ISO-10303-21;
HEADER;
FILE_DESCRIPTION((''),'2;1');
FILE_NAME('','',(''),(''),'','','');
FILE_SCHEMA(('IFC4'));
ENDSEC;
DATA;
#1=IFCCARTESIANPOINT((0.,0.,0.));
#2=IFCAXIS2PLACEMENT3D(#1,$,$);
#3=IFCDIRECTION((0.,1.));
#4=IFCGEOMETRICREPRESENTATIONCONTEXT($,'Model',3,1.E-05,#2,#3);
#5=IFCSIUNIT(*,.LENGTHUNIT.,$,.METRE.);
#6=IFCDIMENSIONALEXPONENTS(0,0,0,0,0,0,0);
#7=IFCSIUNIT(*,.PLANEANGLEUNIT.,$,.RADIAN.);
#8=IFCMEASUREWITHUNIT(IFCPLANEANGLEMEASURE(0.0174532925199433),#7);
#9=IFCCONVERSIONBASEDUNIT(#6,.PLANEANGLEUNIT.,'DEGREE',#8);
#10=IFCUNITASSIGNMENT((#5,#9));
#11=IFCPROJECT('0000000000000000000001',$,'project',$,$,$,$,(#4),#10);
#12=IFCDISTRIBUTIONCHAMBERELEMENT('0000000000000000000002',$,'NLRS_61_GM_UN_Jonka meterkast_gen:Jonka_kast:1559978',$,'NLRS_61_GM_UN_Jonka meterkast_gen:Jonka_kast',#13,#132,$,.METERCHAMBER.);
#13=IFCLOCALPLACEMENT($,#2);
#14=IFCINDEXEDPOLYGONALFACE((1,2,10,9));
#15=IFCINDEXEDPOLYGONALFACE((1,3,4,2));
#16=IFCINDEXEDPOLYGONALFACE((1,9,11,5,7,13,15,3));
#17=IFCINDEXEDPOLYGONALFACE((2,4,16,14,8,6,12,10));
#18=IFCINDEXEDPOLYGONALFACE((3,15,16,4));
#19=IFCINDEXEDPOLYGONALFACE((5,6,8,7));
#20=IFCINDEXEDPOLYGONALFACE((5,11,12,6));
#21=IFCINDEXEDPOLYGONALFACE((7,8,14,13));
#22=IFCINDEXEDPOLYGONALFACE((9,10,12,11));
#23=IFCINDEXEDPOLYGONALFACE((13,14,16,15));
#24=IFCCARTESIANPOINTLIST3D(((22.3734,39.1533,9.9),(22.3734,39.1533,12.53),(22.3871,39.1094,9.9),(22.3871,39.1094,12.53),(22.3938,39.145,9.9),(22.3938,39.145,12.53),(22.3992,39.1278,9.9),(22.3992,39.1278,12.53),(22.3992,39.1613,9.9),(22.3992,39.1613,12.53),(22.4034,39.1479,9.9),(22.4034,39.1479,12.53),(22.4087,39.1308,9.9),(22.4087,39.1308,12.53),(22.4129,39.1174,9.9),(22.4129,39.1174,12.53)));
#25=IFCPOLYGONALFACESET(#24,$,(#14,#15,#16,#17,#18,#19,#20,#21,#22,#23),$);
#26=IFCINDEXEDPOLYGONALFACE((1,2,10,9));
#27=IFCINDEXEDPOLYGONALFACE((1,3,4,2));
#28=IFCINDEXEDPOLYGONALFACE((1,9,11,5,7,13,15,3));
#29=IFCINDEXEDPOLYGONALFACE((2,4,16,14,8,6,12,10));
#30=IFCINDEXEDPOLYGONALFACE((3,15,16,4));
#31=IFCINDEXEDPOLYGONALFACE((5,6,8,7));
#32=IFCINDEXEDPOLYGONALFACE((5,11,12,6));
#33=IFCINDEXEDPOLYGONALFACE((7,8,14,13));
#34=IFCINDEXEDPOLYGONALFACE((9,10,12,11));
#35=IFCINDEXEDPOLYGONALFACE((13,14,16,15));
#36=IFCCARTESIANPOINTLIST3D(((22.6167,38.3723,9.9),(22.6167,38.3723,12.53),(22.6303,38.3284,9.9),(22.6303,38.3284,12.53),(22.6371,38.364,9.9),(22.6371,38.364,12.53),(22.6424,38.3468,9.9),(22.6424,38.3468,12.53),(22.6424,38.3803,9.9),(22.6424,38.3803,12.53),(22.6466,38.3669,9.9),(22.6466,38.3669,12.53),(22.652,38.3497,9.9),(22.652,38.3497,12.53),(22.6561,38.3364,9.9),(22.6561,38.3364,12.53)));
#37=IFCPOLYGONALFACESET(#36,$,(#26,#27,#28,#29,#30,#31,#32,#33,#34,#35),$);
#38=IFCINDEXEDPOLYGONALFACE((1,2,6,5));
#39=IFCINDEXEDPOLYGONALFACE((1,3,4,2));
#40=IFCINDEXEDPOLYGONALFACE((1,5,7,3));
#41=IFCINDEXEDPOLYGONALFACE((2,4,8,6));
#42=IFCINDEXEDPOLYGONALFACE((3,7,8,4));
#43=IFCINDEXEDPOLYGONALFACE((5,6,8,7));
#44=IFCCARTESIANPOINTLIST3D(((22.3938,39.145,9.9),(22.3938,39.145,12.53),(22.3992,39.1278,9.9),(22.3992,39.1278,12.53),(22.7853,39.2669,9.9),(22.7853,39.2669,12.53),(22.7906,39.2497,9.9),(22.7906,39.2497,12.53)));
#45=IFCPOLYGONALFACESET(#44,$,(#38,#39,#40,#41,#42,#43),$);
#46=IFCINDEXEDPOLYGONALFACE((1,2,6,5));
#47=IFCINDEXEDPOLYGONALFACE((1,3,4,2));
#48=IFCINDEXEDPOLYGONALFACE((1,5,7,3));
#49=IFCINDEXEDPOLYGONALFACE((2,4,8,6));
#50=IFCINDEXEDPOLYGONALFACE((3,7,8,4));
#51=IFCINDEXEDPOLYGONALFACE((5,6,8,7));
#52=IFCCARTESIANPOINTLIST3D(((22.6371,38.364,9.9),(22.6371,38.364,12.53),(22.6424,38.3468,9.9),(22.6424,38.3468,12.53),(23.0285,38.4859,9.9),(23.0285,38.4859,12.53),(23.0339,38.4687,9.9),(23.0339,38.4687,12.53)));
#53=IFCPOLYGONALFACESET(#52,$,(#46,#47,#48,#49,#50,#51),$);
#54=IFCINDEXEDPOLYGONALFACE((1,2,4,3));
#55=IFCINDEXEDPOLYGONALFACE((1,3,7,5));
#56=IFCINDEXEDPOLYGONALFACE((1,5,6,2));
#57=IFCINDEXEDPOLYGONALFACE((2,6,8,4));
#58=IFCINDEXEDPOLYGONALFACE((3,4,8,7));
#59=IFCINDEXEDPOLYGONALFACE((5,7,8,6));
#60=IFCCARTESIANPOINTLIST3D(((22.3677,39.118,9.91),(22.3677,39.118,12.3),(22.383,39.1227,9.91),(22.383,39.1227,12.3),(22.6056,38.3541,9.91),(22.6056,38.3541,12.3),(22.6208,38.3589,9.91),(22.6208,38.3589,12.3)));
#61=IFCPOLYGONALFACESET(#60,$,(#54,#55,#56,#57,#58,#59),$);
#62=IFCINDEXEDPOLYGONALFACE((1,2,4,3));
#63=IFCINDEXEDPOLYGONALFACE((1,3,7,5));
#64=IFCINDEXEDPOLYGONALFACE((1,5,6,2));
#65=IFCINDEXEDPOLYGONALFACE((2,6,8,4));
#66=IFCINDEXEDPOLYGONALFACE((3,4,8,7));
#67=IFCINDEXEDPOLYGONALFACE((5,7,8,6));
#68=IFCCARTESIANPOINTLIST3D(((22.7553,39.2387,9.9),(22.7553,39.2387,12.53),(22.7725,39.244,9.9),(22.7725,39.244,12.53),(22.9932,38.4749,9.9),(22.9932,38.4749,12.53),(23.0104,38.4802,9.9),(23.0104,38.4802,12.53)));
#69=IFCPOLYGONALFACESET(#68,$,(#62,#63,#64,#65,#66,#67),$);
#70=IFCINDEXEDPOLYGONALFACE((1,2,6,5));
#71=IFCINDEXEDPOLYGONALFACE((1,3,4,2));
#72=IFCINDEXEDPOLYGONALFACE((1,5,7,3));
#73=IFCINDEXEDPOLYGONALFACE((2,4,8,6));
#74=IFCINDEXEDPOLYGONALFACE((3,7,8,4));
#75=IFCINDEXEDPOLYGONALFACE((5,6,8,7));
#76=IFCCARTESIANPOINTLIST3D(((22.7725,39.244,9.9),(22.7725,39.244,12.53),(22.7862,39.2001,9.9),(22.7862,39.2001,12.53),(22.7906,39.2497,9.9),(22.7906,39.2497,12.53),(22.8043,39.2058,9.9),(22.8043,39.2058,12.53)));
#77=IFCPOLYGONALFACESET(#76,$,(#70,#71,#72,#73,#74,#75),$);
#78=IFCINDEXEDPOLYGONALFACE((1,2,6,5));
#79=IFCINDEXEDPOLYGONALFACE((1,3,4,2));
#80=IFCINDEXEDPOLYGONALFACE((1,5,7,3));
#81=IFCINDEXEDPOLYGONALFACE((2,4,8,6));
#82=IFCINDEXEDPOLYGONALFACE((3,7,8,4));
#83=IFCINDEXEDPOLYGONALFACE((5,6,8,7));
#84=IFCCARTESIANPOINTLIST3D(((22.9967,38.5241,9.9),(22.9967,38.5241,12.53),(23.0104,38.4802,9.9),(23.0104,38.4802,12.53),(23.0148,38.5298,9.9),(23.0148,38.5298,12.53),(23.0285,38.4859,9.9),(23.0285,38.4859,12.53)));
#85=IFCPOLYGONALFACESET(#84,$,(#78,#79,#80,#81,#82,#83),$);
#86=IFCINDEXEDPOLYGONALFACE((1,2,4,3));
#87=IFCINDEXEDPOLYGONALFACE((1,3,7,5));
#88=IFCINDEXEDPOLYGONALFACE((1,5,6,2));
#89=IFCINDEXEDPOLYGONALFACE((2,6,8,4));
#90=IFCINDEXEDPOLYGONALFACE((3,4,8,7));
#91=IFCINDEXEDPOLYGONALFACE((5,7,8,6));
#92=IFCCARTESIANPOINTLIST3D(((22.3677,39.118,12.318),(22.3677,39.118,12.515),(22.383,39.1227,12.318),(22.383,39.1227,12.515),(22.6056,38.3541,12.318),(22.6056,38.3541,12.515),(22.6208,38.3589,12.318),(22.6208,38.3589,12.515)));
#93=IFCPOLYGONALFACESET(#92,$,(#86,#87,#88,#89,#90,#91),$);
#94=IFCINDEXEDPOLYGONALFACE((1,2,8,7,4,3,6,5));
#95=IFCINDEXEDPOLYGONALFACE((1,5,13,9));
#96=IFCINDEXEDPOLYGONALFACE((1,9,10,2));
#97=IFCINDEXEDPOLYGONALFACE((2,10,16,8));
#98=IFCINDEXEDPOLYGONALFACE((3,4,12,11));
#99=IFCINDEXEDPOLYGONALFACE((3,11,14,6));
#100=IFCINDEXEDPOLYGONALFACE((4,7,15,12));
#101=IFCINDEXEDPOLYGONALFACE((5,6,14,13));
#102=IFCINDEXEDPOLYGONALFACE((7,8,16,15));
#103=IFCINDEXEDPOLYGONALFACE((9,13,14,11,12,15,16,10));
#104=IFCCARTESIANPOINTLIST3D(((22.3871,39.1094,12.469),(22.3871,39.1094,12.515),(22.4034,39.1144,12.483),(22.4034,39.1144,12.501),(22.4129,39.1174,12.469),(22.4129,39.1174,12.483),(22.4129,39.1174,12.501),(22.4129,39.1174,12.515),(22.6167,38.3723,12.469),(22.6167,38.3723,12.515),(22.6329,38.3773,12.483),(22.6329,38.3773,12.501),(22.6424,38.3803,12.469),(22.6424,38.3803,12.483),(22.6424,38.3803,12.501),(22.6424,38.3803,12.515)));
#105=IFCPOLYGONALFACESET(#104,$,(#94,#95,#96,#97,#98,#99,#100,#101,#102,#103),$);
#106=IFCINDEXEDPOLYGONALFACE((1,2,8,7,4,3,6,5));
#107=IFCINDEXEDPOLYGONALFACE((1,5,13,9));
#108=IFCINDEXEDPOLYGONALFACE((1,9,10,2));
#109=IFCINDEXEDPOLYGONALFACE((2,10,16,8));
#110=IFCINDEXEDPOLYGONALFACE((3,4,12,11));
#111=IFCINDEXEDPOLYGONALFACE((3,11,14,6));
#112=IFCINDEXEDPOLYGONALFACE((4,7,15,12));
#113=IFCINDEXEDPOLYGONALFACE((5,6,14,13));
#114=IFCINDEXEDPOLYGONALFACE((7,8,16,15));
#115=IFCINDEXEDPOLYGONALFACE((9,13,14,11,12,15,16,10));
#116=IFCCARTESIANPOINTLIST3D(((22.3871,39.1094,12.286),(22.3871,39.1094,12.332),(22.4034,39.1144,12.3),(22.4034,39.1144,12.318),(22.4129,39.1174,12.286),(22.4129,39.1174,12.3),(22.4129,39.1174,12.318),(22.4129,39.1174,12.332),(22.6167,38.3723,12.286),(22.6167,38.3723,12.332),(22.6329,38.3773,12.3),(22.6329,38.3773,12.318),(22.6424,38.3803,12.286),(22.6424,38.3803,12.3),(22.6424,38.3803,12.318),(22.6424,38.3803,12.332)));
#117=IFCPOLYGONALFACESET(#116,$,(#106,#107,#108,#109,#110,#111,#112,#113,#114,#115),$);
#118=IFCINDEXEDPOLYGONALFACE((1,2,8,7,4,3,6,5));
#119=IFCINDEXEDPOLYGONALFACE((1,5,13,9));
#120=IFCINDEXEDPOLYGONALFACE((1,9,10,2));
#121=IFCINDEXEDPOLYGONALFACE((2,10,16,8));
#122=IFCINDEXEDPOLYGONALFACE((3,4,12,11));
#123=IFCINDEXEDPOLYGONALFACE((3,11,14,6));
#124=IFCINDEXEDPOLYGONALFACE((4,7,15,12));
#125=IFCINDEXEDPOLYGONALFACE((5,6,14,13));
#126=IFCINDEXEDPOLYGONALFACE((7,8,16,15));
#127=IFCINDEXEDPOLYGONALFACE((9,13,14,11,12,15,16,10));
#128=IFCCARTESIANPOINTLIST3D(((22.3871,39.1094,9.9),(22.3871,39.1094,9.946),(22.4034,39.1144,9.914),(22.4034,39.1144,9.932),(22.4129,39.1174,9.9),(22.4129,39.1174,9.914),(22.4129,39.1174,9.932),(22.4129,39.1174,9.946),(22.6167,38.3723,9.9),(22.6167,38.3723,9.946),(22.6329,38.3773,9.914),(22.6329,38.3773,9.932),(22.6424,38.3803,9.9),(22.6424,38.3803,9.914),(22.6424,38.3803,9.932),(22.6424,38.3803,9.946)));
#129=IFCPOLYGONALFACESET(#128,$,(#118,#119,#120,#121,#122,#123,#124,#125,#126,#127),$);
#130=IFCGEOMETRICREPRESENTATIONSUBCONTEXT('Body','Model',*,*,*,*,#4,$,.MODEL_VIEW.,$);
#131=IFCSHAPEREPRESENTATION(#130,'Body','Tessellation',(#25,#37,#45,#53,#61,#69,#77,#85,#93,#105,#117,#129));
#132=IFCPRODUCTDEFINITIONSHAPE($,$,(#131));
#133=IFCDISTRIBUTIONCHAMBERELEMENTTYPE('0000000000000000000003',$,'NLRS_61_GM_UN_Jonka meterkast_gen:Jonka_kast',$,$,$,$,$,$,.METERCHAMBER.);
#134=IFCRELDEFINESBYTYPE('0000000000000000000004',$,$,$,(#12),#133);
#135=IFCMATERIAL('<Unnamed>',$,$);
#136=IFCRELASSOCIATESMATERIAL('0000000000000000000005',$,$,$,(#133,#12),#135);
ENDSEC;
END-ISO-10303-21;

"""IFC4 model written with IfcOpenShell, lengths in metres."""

from ifc_helpers import new_model, entity, si_unit, converted_unit, direction, frame, origin, place, context, subcontext, project, indexed_curve, outline, extrude, source, transform, mapped, material, type_object, type_shapes, element, save


model = new_model("IFC4")

# Units and contexts
model_context = context("Model", 3, precision=1e-05, world=origin(), true_north=direction((0.0, 1.0)))
body_context = subcontext(model_context, "Body", "Model", "MODEL_VIEW")
ifc_project = project(units=[si_unit("LENGTHUNIT", "METRE"), converted_unit("PLANEANGLEUNIT", "DEGREE", entity("IfcPlaneAngleMeasure", 0.0174532925199433), si_unit("PLANEANGLEUNIT", "RADIAN"), dimensions=[0, 0, 0, 0, 0, 0, 0])], contexts=[model_context])

# Distribution chamber element
ifc_material = material(Name="<Unnamed>")
distribution_chamber_element_type = type_object("IfcDistributionChamberElementType", Name="NLRS_61_GM_UN_Jonka meterkast_gen:Jonka_kast", PredefinedType="METERCHAMBER", material=ifc_material)
shared_shape_1 = source(origin(), body_context, "Body", "SweptSolid", [
    extrude(outline(indexed_curve([(-0.0093, -0.023), (0.0178, -0.023), (0.0178, 0.023), (-0.0093, 0.023), (-0.0093, 0.009), (0.0007, 0.009), (0.0007, -0.009), (-0.0093, -0.009), (-0.0093, -0.023)], self_intersect=False)), frame((-0.409, -0.4092, 0.0), z_axis=(0.0, 0.0, 1.0), x_axis=(0.0, -1.0, 0.0)), (0.0, 0.0, 1.0), 2.63),
    extrude(outline(indexed_curve([(-0.0093, -0.023), (0.0178, -0.023), (0.0178, 0.023), (-0.0093, 0.023), (-0.0093, 0.009), (0.0007, 0.009), (0.0007, -0.009), (-0.0093, -0.009), (-0.0093, -0.023)], self_intersect=False)), frame((0.409, -0.4092, 0.0), z_axis=(0.0, 0.0, 1.0), x_axis=(0.0, -1.0, 0.0)), (0.0, 0.0, 1.0), 2.63),
    extrude(outline(indexed_curve([(-0.205, -0.009), (0.205, -0.009), (0.205, 0.009), (-0.205, 0.009), (-0.205, -0.009)], self_intersect=False)), frame((-0.409, -0.205, 0.0), z_axis=(0.0, 0.0, 1.0), x_axis=(0.0, -1.0, 0.0)), (0.0, 0.0, 1.0), 2.63),
    extrude(outline(indexed_curve([(-0.205, -0.009), (0.205, -0.009), (0.205, 0.009), (-0.205, 0.009), (-0.205, -0.009)], self_intersect=False)), frame((0.409, -0.205, 0.0), z_axis=(0.0, 0.0, 1.0), x_axis=(0.0, -1.0, 0.0)), (0.0, 0.0, 1.0), 2.63),
    extrude(outline(indexed_curve([(-0.4, -0.008), (0.4, -0.008), (0.4, 0.008), (-0.4, 0.008), (-0.4, -0.008)], self_intersect=False)), frame((0.0, -0.435, 0.01), z_axis=(0.0, 0.0, 1.0), x_axis=(-1.0, 0.0, 0.0)), (0.0, 0.0, 1.0), 2.39),
    extrude(outline(indexed_curve([(-0.4, -0.009), (0.4, -0.009), (0.4, 0.009), (-0.4, 0.009), (-0.4, -0.009)], self_intersect=False)), frame((0.0, -0.028, 0.0), z_axis=(0.0, 0.0, 1.0), x_axis=(-1.0, 0.0, 0.0)), (0.0, 0.0, 1.0), 2.63),
    extrude(outline(indexed_curve([(-0.023, -0.0095), (0.023, -0.0095), (0.023, 0.0095), (-0.023, 0.0095), (-0.023, -0.0095)], self_intersect=False)), frame((-0.377, -0.0095, 0.0), z_axis=(0.0, 0.0, 1.0), x_axis=(-1.0, 0.0, 0.0)), (0.0, 0.0, 1.0), 2.63),
    extrude(outline(indexed_curve([(-0.023, -0.0095), (0.023, -0.0095), (0.023, 0.0095), (-0.023, 0.0095), (-0.023, -0.0095)], self_intersect=False)), frame((0.377, -0.0095, 0.0), z_axis=(0.0, 0.0, 1.0), x_axis=(-1.0, 0.0, 0.0)), (0.0, 0.0, 1.0), 2.63),
    extrude(outline(indexed_curve([(-0.4, -0.008), (0.4, -0.008), (0.4, 0.008), (-0.4, 0.008), (-0.4, -0.008)], self_intersect=False)), frame((0.0, -0.435, 2.418), z_axis=(0.0, 0.0, 1.0), x_axis=(-1.0, 0.0, 0.0)), (0.0, 0.0, 1.0), 0.197),
    extrude(outline(indexed_curve([(-0.023, -0.0178), (0.023, -0.0178), (0.023, 0.0093), (0.009, 0.0093), (0.009, -0.0007), (-0.009, -0.0007), (-0.009, 0.0093), (-0.023, 0.0093), (-0.023, -0.0178)], self_intersect=False)), frame((-0.386, -0.4092, 2.592), z_axis=(1.0, 0.0, 0.0), x_axis=(0.0, 0.0, -1.0)), (0.0, 0.0, 1.0), 0.772),
    extrude(outline(indexed_curve([(-0.023, -0.0178), (0.023, -0.0178), (0.023, 0.0093), (0.009, 0.0093), (0.009, -0.0007), (-0.009, -0.0007), (-0.009, 0.0093), (-0.023, 0.0093), (-0.023, -0.0178)], self_intersect=False)), frame((-0.386, -0.4092, 2.409), z_axis=(1.0, 0.0, 0.0), x_axis=(0.0, 0.0, -1.0)), (0.0, 0.0, 1.0), 0.772),
    extrude(outline(indexed_curve([(-0.023, -0.0178), (0.023, -0.0178), (0.023, 0.0093), (0.009, 0.0093), (0.009, -0.0007), (-0.009, -0.0007), (-0.009, 0.0093), (-0.023, 0.0093), (-0.023, -0.0178)], self_intersect=False)), frame((-0.386, -0.4092, 0.023), z_axis=(1.0, 0.0, 0.0), x_axis=(0.0, 0.0, -1.0)), (0.0, 0.0, 1.0), 0.772),
])
type_shapes(distribution_chamber_element_type, [shared_shape_1])
placement_1 = place(None, frame((13.1348, 11.9886, 0.0), z_axis=(0.0, 0.0, 1.0), x_axis=(0.954771, 0.297342, 0.0)))
placement_2 = place(placement_1, origin())
placement_3 = place(placement_2, frame((0.0, 0.0, 9.9)))
placement_4 = place(placement_3, origin())
distribution_chamber_element_1_placement = place(placement_4, frame((17.325, 22.757, 0.0), z_axis=(0.0, 0.0, 1.0), x_axis=(0.0, -1.0, 0.0)))
element("IfcDistributionChamberElement", 1, at=distribution_chamber_element_1_placement, type_object=distribution_chamber_element_type, material=ifc_material, Name="NLRS_61_GM_UN_Jonka meterkast_gen:Jonka_kast:1559978", ObjectType="NLRS_61_GM_UN_Jonka meterkast_gen:Jonka_kast", PredefinedType="METERCHAMBER", context=body_context, shape_type="MappedRepresentation", body=[
    mapped(shared_shape_1, transform((0.0, 0.0, 0.0), scale=1.0)),
])

save(model, "model.ifc")
